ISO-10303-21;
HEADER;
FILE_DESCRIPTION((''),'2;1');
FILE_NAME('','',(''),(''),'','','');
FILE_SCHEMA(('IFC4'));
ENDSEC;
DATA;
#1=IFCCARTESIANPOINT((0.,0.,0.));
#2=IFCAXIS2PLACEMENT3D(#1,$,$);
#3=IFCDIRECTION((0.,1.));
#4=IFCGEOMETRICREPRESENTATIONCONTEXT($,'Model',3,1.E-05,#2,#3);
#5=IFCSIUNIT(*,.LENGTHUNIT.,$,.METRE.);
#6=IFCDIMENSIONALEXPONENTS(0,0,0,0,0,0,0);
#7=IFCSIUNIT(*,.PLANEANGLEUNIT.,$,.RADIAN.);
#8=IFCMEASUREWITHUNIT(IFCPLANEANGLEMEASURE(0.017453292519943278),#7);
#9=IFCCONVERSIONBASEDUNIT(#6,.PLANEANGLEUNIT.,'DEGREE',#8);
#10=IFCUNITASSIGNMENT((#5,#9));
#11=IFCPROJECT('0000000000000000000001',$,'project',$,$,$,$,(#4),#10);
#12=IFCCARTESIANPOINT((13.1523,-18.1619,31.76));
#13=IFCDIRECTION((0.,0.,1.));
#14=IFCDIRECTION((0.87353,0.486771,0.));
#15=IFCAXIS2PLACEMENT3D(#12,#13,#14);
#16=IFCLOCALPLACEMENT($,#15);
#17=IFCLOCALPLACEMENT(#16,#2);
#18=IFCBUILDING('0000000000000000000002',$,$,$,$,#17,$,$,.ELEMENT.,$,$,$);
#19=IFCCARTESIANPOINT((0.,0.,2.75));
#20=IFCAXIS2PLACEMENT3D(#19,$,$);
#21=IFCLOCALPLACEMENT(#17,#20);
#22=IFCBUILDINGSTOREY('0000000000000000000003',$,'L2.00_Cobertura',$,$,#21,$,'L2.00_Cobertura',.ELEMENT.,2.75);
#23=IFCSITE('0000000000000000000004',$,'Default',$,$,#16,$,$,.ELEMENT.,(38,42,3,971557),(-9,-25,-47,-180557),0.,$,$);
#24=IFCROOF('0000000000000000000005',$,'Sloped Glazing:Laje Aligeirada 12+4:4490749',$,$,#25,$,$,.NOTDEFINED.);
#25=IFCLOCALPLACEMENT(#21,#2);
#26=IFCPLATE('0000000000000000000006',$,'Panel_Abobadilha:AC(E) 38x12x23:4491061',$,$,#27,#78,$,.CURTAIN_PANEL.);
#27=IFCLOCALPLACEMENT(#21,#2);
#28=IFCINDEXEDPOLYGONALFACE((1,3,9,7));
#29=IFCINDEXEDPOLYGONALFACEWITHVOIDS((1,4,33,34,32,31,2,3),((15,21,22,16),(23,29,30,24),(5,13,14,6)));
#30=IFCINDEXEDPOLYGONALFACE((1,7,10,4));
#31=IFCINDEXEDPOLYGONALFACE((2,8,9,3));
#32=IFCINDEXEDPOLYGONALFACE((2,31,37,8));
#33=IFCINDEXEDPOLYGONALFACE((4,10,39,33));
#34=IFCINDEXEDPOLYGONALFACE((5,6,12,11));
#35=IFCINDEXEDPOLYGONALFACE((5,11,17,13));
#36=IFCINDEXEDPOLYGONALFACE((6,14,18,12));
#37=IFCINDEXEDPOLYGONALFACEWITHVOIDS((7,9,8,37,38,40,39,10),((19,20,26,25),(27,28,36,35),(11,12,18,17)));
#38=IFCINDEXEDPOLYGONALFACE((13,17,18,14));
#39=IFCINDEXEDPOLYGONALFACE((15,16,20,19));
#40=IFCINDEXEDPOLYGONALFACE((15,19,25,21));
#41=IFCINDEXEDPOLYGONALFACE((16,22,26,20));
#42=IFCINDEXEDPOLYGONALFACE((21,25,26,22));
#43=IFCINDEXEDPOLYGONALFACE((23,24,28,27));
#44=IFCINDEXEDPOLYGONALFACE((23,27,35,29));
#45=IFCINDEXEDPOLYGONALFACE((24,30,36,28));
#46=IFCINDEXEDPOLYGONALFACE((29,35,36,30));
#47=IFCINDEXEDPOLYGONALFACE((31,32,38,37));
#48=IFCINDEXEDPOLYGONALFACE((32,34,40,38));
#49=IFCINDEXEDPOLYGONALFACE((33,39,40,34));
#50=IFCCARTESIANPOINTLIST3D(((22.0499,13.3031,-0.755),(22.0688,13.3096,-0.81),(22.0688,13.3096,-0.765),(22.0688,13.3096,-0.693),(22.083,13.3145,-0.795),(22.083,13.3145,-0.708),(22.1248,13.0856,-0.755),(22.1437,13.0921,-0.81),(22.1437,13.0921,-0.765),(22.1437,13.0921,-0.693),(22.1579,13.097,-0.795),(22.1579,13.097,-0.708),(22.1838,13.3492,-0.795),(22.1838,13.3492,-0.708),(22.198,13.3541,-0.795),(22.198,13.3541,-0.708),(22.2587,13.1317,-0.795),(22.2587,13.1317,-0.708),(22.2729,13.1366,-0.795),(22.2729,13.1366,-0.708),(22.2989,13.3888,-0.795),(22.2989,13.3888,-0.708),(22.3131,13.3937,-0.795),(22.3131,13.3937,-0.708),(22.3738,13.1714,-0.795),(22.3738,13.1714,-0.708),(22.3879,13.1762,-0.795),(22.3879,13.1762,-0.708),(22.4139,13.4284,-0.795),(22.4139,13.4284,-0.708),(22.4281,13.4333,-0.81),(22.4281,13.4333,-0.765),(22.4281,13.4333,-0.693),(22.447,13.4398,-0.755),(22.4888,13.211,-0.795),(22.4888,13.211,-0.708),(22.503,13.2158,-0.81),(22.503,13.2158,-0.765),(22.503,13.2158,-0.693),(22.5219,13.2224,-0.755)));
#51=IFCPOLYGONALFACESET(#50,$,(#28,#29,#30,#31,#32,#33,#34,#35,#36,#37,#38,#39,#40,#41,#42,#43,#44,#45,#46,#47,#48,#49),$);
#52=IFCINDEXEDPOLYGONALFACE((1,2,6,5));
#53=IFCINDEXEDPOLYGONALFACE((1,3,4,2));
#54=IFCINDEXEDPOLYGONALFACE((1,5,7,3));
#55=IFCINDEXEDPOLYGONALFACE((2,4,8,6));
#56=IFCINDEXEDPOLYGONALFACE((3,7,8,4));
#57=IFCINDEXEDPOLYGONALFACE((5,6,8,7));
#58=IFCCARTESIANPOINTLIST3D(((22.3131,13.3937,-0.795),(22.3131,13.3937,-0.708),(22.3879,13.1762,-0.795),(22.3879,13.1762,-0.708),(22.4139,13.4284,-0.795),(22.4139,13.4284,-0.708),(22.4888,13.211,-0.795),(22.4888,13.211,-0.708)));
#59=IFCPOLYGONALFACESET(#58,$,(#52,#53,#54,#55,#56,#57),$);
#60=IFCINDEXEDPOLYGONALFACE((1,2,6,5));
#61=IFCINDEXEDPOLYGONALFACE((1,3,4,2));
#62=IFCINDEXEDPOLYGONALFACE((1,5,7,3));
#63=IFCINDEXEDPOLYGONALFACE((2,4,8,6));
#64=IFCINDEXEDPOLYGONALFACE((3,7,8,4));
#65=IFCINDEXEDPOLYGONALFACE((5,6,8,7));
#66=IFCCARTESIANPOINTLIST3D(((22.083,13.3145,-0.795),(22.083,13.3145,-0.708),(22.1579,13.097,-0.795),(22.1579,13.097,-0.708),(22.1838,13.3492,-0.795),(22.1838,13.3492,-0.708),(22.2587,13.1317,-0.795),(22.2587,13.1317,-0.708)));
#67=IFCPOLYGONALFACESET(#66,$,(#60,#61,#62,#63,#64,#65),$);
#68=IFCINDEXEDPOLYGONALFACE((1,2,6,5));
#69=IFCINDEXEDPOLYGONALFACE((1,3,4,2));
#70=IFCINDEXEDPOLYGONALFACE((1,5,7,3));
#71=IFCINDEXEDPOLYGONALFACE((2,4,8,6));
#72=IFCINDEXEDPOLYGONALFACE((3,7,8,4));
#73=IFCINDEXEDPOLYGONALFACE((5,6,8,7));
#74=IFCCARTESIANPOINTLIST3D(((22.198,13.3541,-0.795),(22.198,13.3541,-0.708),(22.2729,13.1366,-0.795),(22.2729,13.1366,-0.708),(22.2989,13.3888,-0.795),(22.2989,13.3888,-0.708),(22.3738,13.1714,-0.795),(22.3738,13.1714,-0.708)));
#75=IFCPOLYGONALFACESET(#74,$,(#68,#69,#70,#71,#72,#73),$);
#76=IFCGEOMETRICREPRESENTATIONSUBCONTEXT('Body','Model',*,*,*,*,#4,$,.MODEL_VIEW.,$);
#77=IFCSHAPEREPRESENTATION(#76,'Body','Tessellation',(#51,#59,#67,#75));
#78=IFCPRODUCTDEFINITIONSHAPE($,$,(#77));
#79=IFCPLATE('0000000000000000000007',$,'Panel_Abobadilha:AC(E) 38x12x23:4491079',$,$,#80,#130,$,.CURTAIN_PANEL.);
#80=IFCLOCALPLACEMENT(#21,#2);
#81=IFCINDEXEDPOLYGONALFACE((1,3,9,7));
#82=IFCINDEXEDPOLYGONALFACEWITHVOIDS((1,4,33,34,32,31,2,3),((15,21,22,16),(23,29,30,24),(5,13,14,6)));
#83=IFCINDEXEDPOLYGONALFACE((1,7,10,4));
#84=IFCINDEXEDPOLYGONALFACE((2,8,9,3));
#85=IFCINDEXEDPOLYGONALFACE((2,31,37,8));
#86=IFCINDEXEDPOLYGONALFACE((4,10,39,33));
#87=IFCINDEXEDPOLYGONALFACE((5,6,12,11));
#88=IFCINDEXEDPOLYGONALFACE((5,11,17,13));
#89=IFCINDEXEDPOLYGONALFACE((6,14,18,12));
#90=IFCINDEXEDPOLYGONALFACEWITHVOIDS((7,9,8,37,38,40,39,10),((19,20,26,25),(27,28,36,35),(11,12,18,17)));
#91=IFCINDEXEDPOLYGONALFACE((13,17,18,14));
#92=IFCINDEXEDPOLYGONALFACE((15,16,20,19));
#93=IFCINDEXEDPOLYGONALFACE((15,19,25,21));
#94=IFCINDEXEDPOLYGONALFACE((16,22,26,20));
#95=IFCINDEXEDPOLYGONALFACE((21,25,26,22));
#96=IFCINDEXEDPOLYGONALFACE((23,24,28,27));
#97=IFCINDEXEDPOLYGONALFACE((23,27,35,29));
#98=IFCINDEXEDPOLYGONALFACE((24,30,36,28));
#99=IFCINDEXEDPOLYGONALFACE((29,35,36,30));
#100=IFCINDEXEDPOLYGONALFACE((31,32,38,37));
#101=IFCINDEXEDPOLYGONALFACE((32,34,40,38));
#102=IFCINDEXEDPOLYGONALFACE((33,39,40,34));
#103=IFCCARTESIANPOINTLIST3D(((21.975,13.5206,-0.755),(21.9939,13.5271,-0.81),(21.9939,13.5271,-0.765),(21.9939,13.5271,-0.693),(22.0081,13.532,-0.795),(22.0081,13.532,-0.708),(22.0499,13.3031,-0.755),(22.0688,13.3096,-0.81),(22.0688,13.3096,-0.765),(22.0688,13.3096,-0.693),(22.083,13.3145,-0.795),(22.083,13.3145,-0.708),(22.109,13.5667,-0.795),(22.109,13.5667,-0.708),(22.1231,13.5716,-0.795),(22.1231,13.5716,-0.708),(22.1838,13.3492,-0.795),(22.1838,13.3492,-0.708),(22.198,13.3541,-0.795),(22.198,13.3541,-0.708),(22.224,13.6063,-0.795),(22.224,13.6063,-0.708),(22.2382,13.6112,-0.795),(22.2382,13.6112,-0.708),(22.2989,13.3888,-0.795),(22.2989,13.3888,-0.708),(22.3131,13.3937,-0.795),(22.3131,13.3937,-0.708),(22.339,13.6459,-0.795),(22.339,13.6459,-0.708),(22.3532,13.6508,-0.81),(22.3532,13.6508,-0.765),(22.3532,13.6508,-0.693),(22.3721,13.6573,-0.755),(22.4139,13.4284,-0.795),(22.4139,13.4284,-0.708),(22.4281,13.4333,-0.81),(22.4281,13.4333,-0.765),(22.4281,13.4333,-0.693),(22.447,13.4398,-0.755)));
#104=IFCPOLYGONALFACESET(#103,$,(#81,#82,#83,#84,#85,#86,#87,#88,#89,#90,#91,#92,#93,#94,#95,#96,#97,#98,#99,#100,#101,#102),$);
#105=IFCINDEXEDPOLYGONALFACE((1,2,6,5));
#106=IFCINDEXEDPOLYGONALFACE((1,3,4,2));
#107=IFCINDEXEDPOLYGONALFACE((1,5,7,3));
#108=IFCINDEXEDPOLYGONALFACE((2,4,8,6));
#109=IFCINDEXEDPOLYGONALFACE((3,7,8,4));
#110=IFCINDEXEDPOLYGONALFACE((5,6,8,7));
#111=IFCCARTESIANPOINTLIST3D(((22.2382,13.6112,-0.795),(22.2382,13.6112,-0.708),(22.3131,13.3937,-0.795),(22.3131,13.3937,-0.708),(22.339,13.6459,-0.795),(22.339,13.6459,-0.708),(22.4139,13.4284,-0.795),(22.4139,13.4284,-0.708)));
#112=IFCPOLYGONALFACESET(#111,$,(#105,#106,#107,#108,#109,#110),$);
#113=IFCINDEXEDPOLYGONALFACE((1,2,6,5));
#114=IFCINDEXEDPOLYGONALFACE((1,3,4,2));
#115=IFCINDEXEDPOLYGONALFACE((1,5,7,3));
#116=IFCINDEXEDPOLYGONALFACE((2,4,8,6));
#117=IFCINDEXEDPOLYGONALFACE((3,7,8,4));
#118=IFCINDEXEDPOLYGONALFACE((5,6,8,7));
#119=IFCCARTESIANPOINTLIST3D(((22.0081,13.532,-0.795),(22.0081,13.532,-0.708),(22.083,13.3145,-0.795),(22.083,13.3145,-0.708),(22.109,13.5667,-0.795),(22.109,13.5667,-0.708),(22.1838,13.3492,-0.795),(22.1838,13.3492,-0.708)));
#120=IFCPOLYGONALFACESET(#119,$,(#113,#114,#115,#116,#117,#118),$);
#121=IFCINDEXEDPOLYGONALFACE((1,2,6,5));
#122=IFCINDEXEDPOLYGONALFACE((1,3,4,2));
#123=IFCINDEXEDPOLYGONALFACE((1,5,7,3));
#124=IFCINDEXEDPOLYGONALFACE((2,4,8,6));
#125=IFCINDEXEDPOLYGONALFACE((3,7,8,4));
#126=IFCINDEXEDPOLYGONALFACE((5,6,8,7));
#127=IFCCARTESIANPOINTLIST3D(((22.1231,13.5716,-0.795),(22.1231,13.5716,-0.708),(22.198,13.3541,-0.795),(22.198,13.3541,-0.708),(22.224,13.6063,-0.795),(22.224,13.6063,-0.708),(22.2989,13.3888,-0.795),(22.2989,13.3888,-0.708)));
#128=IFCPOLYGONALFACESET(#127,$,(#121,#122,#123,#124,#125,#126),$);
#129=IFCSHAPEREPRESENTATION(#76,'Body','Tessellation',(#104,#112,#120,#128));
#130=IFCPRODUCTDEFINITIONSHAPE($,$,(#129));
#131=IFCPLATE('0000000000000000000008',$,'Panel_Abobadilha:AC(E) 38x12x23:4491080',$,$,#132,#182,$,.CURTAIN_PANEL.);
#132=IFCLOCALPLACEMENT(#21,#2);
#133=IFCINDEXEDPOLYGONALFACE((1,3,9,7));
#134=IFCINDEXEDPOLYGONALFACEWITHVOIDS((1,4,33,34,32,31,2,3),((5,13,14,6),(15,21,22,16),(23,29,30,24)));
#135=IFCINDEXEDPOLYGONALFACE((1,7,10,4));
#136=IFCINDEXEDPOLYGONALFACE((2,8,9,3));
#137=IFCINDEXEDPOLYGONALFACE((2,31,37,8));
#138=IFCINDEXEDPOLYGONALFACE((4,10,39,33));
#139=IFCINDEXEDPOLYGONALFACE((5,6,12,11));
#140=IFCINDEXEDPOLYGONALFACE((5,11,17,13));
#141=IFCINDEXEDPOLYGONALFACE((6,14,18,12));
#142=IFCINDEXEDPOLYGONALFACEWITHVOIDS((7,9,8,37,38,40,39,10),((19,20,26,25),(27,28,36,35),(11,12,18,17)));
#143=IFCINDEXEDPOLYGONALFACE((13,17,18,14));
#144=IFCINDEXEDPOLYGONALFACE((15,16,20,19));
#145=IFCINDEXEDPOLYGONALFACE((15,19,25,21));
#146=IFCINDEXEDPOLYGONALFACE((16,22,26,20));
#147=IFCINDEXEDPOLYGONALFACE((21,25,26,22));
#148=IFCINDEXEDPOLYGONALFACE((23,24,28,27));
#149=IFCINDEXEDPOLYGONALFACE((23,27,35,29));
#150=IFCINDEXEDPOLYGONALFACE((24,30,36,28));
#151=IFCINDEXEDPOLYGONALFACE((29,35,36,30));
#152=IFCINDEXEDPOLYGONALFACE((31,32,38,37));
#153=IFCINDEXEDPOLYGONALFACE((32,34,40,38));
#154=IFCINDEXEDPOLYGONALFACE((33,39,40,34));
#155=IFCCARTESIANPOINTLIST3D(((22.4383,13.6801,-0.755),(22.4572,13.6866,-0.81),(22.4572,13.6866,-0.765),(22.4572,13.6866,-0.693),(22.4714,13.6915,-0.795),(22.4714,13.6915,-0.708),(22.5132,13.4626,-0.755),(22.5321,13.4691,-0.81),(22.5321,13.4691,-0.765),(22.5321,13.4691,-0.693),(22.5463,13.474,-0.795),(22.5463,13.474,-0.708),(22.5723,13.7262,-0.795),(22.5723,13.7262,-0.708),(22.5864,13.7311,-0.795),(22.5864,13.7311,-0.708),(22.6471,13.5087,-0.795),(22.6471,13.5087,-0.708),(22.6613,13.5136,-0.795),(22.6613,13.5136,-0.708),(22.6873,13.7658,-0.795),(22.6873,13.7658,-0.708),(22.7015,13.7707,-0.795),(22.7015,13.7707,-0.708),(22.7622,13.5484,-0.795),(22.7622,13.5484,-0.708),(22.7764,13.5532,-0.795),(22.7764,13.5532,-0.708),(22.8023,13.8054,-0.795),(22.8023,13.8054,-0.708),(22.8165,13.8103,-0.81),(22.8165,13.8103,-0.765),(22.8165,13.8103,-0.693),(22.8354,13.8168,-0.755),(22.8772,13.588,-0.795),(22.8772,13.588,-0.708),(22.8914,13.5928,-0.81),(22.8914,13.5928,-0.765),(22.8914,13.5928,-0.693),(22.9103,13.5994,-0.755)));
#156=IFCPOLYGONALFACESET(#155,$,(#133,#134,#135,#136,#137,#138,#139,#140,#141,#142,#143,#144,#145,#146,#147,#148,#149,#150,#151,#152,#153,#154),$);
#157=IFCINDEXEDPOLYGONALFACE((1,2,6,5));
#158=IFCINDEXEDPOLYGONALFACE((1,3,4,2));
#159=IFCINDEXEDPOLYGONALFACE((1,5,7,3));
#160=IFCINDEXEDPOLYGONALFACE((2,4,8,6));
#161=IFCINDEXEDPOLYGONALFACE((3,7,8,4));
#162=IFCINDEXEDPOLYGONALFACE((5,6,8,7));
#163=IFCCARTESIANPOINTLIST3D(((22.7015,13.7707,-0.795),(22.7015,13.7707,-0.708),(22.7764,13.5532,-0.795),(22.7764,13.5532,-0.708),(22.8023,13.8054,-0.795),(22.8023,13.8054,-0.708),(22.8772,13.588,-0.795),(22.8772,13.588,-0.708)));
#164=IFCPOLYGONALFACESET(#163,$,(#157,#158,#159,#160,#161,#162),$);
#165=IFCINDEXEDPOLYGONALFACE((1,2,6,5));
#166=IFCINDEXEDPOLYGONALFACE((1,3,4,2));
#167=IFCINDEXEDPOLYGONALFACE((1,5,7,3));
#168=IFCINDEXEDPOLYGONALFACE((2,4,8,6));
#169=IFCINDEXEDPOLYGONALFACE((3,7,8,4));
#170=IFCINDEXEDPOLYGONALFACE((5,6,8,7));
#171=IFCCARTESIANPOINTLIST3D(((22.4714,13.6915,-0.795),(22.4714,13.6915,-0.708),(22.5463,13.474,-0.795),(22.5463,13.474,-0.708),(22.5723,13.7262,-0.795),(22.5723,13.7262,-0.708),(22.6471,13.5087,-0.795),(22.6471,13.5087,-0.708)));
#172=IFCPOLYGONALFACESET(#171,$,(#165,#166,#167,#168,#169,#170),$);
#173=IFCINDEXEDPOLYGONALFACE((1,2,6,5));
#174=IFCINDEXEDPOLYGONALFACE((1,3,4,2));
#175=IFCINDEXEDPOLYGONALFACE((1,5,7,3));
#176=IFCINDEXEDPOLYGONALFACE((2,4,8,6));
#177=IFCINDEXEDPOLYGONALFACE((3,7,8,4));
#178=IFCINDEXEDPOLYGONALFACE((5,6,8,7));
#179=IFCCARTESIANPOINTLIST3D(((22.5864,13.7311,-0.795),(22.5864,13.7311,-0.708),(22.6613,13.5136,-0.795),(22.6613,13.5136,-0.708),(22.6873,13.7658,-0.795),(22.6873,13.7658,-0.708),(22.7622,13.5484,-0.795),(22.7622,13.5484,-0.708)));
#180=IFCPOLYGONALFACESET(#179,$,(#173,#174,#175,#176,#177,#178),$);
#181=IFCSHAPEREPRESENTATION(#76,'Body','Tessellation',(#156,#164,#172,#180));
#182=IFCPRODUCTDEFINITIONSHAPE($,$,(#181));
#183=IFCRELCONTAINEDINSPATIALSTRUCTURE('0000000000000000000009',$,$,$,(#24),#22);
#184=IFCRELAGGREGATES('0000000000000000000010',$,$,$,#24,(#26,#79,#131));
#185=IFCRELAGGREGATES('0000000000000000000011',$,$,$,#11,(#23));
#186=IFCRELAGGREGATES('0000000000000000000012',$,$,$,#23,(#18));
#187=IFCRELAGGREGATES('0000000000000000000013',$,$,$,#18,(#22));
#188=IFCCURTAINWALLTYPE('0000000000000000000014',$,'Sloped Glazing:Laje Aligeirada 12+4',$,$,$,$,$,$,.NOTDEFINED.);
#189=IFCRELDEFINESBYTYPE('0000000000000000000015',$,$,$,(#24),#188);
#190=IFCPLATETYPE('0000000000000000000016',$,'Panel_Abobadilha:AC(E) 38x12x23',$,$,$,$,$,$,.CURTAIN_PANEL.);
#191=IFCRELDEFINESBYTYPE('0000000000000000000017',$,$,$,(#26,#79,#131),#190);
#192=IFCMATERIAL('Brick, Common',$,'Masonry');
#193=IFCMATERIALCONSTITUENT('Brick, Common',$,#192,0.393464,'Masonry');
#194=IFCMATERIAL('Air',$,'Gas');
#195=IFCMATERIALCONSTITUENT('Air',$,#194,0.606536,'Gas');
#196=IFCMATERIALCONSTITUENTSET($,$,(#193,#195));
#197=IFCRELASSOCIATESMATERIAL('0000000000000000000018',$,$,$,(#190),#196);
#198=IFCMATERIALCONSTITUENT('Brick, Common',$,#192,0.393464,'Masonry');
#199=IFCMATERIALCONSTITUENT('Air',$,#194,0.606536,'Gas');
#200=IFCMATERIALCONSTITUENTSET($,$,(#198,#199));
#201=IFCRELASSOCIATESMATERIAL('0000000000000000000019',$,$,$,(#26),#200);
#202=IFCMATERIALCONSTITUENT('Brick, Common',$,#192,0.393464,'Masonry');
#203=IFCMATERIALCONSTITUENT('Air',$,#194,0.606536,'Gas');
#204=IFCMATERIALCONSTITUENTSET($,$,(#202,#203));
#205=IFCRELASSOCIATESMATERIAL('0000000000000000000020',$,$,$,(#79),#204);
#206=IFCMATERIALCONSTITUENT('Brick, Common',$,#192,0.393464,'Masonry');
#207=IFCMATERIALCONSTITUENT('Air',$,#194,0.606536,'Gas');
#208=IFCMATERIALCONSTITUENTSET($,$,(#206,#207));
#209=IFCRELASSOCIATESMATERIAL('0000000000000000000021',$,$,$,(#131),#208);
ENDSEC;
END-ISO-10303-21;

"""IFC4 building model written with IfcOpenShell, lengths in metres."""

from ifc_helpers import new_model, entity, si_unit, converted_unit, direction, frame, origin, place, context, subcontext, project, spatial, indexed_curve, outline, extrude, source, transform, mapped, material, constituent, constituent_set, type_object, type_shapes, element, aggregate, save


model = new_model("IFC4")

# Units and contexts
model_context = context("Model", 3, precision=1e-05, world=origin(), true_north=direction((0.0, 1.0)))
body_context = subcontext(model_context, "Body", "Model", "MODEL_VIEW")
ifc_project = project(units=[si_unit("LENGTHUNIT", "METRE"), converted_unit("PLANEANGLEUNIT", "DEGREE", entity("IfcPlaneAngleMeasure", 0.017453292519943278), si_unit("PLANEANGLEUNIT", "RADIAN"), dimensions=[0, 0, 0, 0, 0, 0, 0])], contexts=[model_context])

# Site, building, storey
site_placement = place(None, frame((13.1523, -18.1619, 31.76), z_axis=(0.0, 0.0, 1.0), x_axis=(0.87353, 0.486771, 0.0)))
site = spatial("IfcSite", under=ifc_project, at=site_placement, Name="Default", CompositionType="ELEMENT", RefLatitude=(38, 42, 3, 971557), RefLongitude=(-9, -25, -47, -180557), RefElevation=0.0)
building_placement = place(site_placement, origin())
building = spatial("IfcBuilding", under=site, at=building_placement, CompositionType="ELEMENT")
storey_placement = place(building_placement, frame((0.0, 0.0, 2.75)))
storey = spatial("IfcBuildingStorey", under=building, at=storey_placement, Name="L2.00_Cobertura", LongName="L2.00_Cobertura", CompositionType="ELEMENT", Elevation=2.75)

# Roof, plates
curtain_wall_type = type_object("IfcCurtainWallType", Name="Sloped Glazing:Laje Aligeirada 12+4", PredefinedType="NOTDEFINED")
roof_placement = place(storey_placement, frame((0.0, 0.0, -2.75)))
roof = element("IfcRoof", 1, at=roof_placement, inside=storey, type_object=curtain_wall_type, Name="Sloped Glazing:Laje Aligeirada 12+4:4490749", PredefinedType="NOTDEFINED")
ifc_material_1 = material(Name="Brick, Common", Category="Masonry")
ifc_constituent_1 = constituent(ifc_material_1, Name="Brick, Common", Category="Masonry", fraction=0.393464)
ifc_material_2 = material(Name="Air", Category="Gas")
ifc_constituent_2 = constituent(ifc_material_2, Name="Air", Category="Gas", fraction=0.606536)
ifc_constituent_set_1 = constituent_set(constituents=[ifc_constituent_1, ifc_constituent_2])
ifc_constituent_3 = constituent(ifc_material_1, Name="Brick, Common", Category="Masonry", fraction=0.393464)
ifc_constituent_4 = constituent(ifc_material_2, Name="Air", Category="Gas", fraction=0.606536)
ifc_constituent_set_2 = constituent_set(constituents=[ifc_constituent_3, ifc_constituent_4])
plate_type = type_object("IfcPlateType", Name="Panel_Abobadilha:AC(E) 38x12x23", PredefinedType="CURTAIN_PANEL", material=ifc_constituent_set_2)
shared_shape_1 = source(origin(), body_context, "Body", "SweptSolid", [
    extrude(outline(indexed_curve([(-0.19, -0.0543), (0.19, -0.0543), (0.19, -0.0093), (0.21, 0.0007), (0.19, 0.0628), (-0.19, 0.0628), (-0.21, 0.0007), (-0.19, -0.0093), (-0.19, -0.0543)], self_intersect=False), holes=[indexed_curve([(-0.0683, 0.0477), (-0.0683, -0.0393), (-0.175, -0.0393), (-0.175, 0.0477), (-0.0683, 0.0477)], self_intersect=False), indexed_curve([(0.0533, 0.0477), (0.0533, -0.0393), (-0.0533, -0.0393), (-0.0533, 0.0477), (0.0533, 0.0477)], self_intersect=False), indexed_curve([(0.175, 0.0477), (0.175, -0.0393), (0.0683, -0.0393), (0.0683, 0.0477), (0.175, 0.0477)], self_intersect=False)]), frame((0.0, 0.0543, 0.0)), (0.0, 0.0, 1.0), 0.23),
    extrude(outline(indexed_curve([(-0.0533, -0.0435), (0.0533, -0.0435), (0.0533, 0.0435), (-0.0533, 0.0435), (-0.0533, -0.0435)], self_intersect=False)), frame((0.1217, 0.0585, 0.0), z_axis=(0.0, 0.0, 1.0), x_axis=(-1.0, 0.0, 0.0)), (0.0, 0.0, 1.0), 0.23),
    extrude(outline(indexed_curve([(-0.0533, -0.0435), (0.0533, -0.0435), (0.0533, 0.0435), (-0.0533, 0.0435), (-0.0533, -0.0435)], self_intersect=False)), frame((-0.1217, 0.0585, 0.0), z_axis=(0.0, 0.0, 1.0), x_axis=(-1.0, 0.0, 0.0)), (0.0, 0.0, 1.0), 0.23),
    extrude(outline(indexed_curve([(-0.0533, -0.0435), (0.0533, -0.0435), (0.0533, 0.0435), (-0.0533, 0.0435), (-0.0533, -0.0435)], self_intersect=False)), frame((0.0, 0.0585, 0.0), z_axis=(0.0, 0.0, 1.0), x_axis=(-1.0, 0.0, 0.0)), (0.0, 0.0, 1.0), 0.23),
])
type_shapes(plate_type, [shared_shape_1])
plate_1_placement = place(roof_placement, frame((22.2484, 13.3715, 1.94), z_axis=(0.325568, -0.945519, 0.0), x_axis=(0.945519, 0.325568, 0.0)))
plate_1 = element("IfcPlate", 2, at=plate_1_placement, type_object=plate_type, material=ifc_constituent_set_1, Name="Panel_Abobadilha:AC(E) 38x12x23:4491061", PredefinedType="CURTAIN_PANEL", context=body_context, shape_type="MappedRepresentation", body=[
    mapped(shared_shape_1, transform((0.0, 0.0, 0.0), scale=1.0)),
])
ifc_constituent_5 = constituent(ifc_material_1, Name="Brick, Common", Category="Masonry", fraction=0.393464)
ifc_constituent_6 = constituent(ifc_material_2, Name="Air", Category="Gas", fraction=0.606536)
ifc_constituent_set_3 = constituent_set(constituents=[ifc_constituent_5, ifc_constituent_6])
plate_2_placement = place(roof_placement, frame((22.1736, 13.5889, 1.94), z_axis=(0.325568, -0.945519, 0.0), x_axis=(0.945519, 0.325568, 0.0)))
plate_2 = element("IfcPlate", 3, at=plate_2_placement, type_object=plate_type, material=ifc_constituent_set_3, Name="Panel_Abobadilha:AC(E) 38x12x23:4491079", PredefinedType="CURTAIN_PANEL", context=body_context, shape_type="MappedRepresentation", body=[
    mapped(shared_shape_1, transform((0.0, 0.0, 0.0), scale=1.0)),
])
ifc_constituent_7 = constituent(ifc_material_1, Name="Brick, Common", Category="Masonry", fraction=0.393464)
ifc_constituent_8 = constituent(ifc_material_2, Name="Air", Category="Gas", fraction=0.606536)
ifc_constituent_set_4 = constituent_set(constituents=[ifc_constituent_7, ifc_constituent_8])
plate_3_placement = place(roof_placement, frame((22.6369, 13.7485, 1.94), z_axis=(0.325568, -0.945519, 0.0), x_axis=(0.945519, 0.325568, 0.0)))
plate_3 = element("IfcPlate", 4, at=plate_3_placement, type_object=plate_type, material=ifc_constituent_set_4, Name="Panel_Abobadilha:AC(E) 38x12x23:4491080", PredefinedType="CURTAIN_PANEL", context=body_context, shape_type="MappedRepresentation", body=[
    mapped(shared_shape_1, transform((0.0, 0.0, 0.0), scale=1.0)),
])
aggregate(roof, [plate_1, plate_2, plate_3])

save(model, "model.ifc")
